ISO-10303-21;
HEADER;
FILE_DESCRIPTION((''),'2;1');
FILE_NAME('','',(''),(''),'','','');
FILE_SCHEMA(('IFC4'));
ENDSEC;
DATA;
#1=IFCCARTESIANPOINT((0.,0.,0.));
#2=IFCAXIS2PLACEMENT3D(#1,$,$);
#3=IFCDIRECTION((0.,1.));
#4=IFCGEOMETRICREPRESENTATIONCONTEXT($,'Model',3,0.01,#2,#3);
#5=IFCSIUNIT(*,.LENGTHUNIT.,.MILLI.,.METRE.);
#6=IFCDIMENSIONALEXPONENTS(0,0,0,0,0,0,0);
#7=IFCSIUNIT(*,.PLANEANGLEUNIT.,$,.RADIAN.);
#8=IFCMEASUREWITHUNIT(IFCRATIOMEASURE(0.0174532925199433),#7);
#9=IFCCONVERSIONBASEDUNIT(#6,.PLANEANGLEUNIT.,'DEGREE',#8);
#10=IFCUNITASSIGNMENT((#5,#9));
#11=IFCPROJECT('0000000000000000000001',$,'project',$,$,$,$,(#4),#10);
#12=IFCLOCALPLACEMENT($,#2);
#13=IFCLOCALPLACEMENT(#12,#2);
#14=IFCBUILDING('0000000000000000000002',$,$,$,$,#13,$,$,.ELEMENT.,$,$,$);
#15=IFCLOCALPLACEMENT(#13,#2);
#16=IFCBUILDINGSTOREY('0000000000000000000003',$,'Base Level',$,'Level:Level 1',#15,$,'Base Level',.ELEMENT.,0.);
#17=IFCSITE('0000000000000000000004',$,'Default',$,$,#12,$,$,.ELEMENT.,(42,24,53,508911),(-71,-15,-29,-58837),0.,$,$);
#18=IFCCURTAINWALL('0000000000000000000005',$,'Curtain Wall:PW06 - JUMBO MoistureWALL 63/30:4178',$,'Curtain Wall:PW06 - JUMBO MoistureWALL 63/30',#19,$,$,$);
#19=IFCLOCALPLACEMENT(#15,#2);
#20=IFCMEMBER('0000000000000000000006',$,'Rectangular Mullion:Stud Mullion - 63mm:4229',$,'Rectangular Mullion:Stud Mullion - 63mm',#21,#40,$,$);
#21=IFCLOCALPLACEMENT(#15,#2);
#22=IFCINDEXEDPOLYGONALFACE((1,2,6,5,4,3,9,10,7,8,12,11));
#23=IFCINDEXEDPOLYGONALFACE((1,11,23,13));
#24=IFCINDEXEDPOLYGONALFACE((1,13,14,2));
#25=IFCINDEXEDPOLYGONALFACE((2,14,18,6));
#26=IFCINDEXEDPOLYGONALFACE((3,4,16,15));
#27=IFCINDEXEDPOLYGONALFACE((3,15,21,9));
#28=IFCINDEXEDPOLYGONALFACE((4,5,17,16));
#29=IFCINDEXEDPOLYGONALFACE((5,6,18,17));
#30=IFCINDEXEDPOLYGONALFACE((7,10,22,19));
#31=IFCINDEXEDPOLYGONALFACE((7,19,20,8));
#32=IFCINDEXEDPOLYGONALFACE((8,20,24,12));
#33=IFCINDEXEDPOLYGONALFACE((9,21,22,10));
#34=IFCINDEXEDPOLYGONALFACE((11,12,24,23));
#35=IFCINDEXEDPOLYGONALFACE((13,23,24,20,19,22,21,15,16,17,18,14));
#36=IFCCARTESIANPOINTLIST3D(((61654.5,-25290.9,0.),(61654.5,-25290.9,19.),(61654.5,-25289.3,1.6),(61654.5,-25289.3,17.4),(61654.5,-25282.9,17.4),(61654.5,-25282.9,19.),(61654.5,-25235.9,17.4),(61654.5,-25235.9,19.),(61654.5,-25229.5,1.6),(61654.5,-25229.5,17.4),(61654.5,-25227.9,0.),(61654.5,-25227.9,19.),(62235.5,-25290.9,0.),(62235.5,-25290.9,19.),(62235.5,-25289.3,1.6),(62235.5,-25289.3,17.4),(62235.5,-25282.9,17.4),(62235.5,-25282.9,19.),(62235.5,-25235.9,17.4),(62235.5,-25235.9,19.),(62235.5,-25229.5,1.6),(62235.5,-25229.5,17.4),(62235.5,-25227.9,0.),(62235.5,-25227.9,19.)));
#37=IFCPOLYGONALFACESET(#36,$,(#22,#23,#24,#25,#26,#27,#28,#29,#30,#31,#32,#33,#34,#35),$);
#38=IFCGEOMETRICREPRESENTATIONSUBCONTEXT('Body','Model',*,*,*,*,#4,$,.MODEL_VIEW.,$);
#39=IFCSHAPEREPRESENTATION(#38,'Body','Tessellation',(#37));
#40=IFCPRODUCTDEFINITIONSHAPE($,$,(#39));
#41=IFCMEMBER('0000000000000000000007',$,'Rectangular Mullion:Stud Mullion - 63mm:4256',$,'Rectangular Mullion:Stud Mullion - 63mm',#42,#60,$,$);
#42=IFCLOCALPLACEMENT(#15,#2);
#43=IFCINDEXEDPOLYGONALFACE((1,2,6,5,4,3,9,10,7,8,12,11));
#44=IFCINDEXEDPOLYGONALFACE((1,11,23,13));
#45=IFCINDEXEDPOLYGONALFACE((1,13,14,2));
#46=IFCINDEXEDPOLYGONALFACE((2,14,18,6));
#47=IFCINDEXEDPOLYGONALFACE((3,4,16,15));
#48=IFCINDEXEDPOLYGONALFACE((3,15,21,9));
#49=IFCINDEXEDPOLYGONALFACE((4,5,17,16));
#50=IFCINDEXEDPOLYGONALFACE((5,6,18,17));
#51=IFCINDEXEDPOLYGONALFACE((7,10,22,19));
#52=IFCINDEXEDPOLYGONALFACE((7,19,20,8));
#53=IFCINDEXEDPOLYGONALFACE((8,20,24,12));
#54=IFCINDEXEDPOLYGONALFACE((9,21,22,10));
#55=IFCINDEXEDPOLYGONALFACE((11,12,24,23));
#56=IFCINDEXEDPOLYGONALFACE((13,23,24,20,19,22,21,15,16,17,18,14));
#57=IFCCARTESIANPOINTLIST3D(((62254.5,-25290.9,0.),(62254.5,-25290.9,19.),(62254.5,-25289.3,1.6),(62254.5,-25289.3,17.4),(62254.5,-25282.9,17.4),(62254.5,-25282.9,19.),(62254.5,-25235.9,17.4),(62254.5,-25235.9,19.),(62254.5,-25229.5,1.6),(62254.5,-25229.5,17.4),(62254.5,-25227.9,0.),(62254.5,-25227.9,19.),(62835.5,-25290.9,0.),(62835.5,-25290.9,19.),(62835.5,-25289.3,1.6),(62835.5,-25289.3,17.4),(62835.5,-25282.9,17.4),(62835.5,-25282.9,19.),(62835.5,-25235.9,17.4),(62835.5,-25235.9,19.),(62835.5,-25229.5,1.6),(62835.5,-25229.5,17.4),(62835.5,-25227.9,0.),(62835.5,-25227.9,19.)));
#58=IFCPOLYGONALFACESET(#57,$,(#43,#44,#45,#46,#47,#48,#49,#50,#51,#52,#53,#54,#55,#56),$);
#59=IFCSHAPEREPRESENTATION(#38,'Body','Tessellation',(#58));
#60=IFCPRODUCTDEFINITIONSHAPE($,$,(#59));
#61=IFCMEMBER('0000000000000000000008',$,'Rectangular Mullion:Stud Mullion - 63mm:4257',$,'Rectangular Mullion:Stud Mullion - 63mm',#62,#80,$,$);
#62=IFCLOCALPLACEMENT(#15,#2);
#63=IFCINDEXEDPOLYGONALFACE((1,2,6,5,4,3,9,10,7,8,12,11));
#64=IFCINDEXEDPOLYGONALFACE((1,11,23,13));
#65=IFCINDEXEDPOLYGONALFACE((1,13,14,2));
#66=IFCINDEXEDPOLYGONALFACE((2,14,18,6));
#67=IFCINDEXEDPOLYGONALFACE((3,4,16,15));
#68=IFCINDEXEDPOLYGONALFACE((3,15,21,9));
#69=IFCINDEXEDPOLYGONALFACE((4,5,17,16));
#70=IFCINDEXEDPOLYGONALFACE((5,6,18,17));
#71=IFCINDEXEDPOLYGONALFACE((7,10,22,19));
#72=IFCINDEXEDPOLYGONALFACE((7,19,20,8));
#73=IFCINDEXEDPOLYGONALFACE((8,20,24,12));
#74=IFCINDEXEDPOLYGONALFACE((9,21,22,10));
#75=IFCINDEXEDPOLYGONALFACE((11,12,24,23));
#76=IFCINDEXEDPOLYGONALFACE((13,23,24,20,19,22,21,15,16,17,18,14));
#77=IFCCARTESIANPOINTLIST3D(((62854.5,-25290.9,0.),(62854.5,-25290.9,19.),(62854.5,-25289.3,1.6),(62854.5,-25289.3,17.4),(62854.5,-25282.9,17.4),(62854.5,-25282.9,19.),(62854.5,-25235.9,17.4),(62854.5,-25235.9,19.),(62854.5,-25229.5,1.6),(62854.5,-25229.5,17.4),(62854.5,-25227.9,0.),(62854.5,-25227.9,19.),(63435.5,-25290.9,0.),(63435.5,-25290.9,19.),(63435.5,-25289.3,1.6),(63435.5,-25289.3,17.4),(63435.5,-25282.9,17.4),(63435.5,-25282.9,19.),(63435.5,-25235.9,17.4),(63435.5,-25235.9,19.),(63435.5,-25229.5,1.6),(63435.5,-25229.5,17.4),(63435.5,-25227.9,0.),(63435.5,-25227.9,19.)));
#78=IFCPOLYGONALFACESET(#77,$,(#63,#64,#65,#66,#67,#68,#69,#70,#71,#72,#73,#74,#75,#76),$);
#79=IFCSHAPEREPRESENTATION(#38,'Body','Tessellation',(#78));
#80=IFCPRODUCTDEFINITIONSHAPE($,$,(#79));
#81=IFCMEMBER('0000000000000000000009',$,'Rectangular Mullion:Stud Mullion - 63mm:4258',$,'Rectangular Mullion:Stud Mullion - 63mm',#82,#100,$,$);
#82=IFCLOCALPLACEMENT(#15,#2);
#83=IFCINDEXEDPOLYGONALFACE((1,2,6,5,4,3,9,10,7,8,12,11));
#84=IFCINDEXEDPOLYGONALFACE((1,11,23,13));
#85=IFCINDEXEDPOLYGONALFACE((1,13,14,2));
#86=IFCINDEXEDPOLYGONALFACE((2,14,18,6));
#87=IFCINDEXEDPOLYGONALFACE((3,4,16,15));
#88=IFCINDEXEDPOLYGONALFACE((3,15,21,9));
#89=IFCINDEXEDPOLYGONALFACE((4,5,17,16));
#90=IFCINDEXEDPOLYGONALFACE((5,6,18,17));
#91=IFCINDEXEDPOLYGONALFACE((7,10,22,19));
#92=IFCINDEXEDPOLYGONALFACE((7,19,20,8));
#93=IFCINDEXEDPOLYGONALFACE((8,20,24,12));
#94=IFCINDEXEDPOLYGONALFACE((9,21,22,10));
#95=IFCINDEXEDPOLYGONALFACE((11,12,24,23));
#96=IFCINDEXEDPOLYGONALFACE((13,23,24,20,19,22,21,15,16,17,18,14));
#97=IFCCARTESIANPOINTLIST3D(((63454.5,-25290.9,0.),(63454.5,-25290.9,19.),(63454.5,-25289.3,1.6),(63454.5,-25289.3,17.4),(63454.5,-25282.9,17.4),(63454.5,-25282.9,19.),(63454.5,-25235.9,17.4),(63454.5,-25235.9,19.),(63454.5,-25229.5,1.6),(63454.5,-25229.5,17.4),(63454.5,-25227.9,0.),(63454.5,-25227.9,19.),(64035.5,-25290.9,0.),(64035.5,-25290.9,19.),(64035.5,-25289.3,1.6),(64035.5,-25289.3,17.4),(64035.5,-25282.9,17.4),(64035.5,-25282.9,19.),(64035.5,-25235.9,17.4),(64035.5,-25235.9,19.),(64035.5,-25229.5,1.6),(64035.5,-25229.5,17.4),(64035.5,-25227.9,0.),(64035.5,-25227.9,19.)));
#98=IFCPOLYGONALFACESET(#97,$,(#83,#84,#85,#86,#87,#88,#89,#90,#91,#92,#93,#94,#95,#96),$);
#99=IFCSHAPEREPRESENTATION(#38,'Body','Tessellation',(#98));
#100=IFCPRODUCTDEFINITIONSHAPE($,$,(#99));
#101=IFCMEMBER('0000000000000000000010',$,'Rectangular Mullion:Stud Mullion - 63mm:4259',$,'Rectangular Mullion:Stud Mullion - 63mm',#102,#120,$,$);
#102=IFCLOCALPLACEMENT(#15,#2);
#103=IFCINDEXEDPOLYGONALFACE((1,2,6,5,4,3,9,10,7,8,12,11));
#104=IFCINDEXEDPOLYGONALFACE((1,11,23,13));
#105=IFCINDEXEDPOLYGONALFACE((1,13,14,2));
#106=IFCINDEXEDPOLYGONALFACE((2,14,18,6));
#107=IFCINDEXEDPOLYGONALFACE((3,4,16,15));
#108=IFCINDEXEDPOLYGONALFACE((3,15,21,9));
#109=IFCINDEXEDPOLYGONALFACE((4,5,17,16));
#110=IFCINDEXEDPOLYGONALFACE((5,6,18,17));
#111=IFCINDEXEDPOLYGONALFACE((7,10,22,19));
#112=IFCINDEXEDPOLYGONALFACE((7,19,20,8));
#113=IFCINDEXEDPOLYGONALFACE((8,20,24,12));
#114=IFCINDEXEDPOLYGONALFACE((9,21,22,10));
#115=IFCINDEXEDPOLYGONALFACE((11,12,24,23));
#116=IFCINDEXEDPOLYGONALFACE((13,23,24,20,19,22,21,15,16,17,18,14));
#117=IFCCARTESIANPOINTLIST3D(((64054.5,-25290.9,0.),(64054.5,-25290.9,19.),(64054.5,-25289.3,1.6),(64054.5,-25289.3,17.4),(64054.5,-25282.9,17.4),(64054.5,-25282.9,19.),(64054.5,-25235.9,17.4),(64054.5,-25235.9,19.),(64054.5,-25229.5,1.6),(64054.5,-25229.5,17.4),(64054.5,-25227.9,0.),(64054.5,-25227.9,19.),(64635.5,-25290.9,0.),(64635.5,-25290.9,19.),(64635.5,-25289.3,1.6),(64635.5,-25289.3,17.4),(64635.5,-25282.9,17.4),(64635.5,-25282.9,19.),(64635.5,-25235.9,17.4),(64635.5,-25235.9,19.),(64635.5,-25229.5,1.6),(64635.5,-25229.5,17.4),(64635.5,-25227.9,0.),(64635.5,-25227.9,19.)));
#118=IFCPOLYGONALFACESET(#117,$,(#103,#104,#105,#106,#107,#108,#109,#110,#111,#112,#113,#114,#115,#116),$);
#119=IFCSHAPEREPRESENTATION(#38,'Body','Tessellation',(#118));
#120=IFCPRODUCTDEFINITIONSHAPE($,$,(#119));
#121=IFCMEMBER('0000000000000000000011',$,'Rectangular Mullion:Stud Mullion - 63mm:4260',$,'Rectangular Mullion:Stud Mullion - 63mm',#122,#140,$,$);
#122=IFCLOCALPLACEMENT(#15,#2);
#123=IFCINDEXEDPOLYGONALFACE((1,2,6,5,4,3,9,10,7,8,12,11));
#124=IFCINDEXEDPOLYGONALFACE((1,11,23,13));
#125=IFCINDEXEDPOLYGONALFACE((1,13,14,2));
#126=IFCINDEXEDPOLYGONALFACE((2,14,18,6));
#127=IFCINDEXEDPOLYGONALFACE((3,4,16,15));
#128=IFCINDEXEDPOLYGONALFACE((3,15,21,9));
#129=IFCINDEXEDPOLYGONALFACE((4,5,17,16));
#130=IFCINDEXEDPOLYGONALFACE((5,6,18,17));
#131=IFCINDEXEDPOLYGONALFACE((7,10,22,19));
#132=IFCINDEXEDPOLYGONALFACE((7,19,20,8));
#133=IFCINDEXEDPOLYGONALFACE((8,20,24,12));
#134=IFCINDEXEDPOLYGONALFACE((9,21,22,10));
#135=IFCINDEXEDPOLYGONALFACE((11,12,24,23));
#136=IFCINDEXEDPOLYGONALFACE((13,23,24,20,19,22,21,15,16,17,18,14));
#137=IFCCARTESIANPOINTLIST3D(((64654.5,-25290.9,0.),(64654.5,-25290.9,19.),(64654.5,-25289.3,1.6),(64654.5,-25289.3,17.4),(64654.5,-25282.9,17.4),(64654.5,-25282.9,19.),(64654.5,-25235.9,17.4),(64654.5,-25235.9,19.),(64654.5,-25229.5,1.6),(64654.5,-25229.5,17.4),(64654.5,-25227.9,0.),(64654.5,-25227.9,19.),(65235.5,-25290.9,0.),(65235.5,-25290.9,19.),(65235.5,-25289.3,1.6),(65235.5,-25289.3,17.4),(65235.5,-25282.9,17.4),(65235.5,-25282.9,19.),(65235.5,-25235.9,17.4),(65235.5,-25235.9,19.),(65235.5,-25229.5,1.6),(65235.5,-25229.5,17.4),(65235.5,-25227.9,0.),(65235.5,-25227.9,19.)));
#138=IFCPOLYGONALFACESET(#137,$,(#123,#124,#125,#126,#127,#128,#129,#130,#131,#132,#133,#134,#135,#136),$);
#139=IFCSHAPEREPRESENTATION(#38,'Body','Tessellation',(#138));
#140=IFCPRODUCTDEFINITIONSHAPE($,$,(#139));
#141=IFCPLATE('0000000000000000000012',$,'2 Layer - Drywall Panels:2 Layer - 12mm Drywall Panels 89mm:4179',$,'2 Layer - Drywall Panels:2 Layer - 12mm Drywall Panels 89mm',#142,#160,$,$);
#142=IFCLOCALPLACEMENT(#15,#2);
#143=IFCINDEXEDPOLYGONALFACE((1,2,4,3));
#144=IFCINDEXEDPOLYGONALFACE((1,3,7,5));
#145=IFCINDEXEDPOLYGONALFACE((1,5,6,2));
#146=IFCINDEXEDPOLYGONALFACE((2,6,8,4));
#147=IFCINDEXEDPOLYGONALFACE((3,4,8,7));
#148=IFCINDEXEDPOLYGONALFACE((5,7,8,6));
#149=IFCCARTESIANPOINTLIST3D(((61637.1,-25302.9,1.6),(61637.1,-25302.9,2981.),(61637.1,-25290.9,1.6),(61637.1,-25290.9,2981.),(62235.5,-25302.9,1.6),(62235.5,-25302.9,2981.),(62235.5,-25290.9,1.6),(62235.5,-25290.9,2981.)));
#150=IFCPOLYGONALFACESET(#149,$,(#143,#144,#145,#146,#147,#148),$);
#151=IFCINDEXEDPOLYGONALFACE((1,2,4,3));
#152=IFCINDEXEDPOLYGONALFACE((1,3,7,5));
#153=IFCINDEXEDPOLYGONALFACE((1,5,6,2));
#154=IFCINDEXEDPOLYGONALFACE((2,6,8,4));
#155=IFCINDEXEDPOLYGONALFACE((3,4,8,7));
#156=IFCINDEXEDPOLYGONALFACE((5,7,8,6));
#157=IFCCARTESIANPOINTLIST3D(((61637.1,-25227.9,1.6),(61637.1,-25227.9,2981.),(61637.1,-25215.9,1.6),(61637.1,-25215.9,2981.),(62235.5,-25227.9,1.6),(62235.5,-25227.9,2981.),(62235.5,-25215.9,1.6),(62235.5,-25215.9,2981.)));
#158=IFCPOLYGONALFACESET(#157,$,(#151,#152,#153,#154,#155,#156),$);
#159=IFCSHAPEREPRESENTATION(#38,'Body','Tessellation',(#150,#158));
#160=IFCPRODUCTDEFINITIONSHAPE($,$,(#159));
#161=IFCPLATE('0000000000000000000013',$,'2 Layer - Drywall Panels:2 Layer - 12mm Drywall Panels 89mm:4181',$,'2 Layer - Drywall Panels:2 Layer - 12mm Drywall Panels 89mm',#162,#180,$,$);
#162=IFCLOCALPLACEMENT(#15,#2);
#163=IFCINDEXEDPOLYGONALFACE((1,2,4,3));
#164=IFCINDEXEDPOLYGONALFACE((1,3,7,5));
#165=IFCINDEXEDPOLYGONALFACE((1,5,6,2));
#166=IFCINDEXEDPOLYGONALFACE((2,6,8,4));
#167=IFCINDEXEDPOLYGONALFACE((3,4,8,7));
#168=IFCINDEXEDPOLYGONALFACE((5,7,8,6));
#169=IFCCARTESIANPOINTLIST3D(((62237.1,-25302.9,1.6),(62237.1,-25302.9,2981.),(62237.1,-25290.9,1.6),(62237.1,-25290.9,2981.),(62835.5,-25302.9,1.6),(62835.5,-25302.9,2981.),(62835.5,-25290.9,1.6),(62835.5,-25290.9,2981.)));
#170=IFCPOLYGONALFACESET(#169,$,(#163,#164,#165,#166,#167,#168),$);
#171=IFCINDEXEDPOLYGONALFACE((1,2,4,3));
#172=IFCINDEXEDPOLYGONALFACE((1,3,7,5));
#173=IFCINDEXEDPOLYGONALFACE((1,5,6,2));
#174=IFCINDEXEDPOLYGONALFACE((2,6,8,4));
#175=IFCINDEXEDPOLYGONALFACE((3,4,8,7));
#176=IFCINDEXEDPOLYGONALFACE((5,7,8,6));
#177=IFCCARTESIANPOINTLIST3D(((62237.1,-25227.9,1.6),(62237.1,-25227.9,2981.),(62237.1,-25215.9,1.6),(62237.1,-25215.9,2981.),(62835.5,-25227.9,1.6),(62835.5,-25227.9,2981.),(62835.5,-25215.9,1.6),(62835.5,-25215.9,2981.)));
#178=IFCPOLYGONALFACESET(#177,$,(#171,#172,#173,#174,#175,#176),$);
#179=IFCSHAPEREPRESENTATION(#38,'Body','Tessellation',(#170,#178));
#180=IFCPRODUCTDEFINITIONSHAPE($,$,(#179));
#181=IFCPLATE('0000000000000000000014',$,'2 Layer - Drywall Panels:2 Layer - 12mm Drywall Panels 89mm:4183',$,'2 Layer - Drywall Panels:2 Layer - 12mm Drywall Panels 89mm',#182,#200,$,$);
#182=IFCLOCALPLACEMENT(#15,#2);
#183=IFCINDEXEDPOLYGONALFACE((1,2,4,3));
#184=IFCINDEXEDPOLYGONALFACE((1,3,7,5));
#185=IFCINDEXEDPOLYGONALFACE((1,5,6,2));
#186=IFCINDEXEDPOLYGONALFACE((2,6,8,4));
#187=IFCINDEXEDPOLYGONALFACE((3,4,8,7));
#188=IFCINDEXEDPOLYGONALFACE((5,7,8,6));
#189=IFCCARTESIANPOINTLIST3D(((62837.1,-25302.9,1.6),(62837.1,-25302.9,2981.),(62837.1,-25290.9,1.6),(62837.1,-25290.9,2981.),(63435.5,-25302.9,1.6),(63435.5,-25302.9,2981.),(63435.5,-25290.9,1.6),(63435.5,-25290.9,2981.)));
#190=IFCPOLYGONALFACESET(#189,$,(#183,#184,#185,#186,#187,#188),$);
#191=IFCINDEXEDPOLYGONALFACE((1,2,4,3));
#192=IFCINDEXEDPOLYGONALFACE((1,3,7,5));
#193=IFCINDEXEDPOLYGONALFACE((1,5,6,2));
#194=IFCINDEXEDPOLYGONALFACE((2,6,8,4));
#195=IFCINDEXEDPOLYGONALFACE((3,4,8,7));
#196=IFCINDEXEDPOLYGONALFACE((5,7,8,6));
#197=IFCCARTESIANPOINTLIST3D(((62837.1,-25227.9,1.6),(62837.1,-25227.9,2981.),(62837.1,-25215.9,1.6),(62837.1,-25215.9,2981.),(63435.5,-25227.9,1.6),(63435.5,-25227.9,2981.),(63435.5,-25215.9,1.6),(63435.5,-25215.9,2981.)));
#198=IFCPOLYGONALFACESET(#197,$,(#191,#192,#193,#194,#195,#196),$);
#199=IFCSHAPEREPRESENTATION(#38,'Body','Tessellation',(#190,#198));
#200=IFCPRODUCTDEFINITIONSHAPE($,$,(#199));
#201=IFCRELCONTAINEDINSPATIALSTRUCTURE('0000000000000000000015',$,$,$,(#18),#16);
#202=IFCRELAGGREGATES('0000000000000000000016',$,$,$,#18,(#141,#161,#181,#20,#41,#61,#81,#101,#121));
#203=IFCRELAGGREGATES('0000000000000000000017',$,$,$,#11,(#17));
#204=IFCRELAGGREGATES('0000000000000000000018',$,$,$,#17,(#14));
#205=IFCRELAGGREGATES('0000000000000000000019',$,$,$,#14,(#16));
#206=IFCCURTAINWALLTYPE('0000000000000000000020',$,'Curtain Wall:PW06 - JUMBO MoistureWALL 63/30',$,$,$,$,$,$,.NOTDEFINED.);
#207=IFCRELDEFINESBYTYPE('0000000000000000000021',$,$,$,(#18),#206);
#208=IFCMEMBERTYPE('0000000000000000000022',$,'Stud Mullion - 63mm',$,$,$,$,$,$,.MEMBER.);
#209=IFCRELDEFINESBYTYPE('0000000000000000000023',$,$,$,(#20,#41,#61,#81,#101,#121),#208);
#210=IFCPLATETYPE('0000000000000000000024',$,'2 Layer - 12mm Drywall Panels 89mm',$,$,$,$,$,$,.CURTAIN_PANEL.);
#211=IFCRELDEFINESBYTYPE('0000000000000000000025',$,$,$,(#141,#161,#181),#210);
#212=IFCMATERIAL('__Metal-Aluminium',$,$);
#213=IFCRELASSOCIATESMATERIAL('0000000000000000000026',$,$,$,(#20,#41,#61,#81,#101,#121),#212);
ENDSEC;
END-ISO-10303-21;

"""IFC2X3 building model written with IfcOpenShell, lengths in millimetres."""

from ifc_helpers import new_model, entity, si_unit, converted_unit, direction, frame, frame_2d, origin, place, context, subcontext, project, spatial, polyline, rectangle, outline, extrude, source, transform, mapped, material, type_object, type_shapes, element, aggregate, save


model = new_model("IFC2X3")

# Units and contexts
model_context = context("Model", 3, precision=0.01, world=origin(), true_north=direction((0.0, 1.0)))
body_context = subcontext(model_context, "Body", "Model", "MODEL_VIEW")
ifc_project = project(units=[si_unit("LENGTHUNIT", "METRE", prefix="MILLI"), converted_unit("PLANEANGLEUNIT", "DEGREE", entity("IfcRatioMeasure", 0.0174532925199433), si_unit("PLANEANGLEUNIT", "RADIAN"), dimensions=[0, 0, 0, 0, 0, 0, 0])], contexts=[model_context])

# Site, building, storey
site_placement = place(None, origin())
site = spatial("IfcSite", under=ifc_project, at=site_placement, Name="Default", CompositionType="ELEMENT", RefLatitude=(42, 24, 53, 508911), RefLongitude=(-71, -15, -29, -58837), RefElevation=0.0)
building_placement = place(site_placement, origin())
building = spatial("IfcBuilding", under=site, at=building_placement, CompositionType="ELEMENT")
storey_placement = place(building_placement, origin())
storey = spatial("IfcBuildingStorey", under=building, at=storey_placement, Name="Base Level", ObjectType="Level:Level 1", LongName="Base Level", CompositionType="ELEMENT", Elevation=0.0)

# Curtain wall, members, plates
curtain_wall_type = type_object("IfcCurtainWallType", Name="Curtain Wall:PW06 - JUMBO MoistureWALL 63/30", PredefinedType="NOTDEFINED")
curtain_wall_placement = place(building_placement, origin())
curtain_wall = element("IfcCurtainWall", 1, at=curtain_wall_placement, inside=storey, type_object=curtain_wall_type, Name="Curtain Wall:PW06 - JUMBO MoistureWALL 63/30:4178", ObjectType="Curtain Wall:PW06 - JUMBO MoistureWALL 63/30")
ifc_material_1 = material(Name="__Metal-Aluminium")
member_type_1 = type_object("IfcMemberType", Name="Stud Mullion - 63mm", PredefinedType="MEMBER")
shared_shape_1 = source(origin(), body_context, "Body", "SweptSolid", [
    extrude(outline(polyline([(23.5, -6.6), (31.5, -6.6), (31.5, 12.4), (-31.5, 12.4), (-31.5, -6.6), (-23.5, -6.6), (-23.5, -5.0), (-29.9, -5.0), (-29.9, 10.8), (29.9, 10.8), (29.9, -5.0), (23.5, -5.0), (23.5, -6.6)])), frame((-12.4, 0.0, -581.0), z_axis=(0.0, 0.0, 1.0), x_axis=(0.0, -1.0, 0.0)), (0.0, 0.0, 1.0), 581.0),
])
type_shapes(member_type_1, [shared_shape_1])
member_1_placement = place(building_placement, frame((61654.5, -25259.4, 0.0), z_axis=(-1.0, 0.0, 0.0), x_axis=(0.0, 0.0, -1.0)))
member_1 = element("IfcMember", 2, at=member_1_placement, type_object=member_type_1, material=ifc_material_1, Name="Rectangular Mullion:Stud Mullion - 63mm:4229", ObjectType="Rectangular Mullion:Stud Mullion - 63mm", context=body_context, shape_type="MappedRepresentation", body=[
    mapped(shared_shape_1, transform((0.0, 0.0, 0.0), scale=1.0)),
])
member_2_placement = place(building_placement, frame((62254.5, -25259.4, 0.0), z_axis=(-1.0, 0.0, 0.0), x_axis=(0.0, 0.0, -1.0)))
member_2 = element("IfcMember", 3, at=member_2_placement, type_object=member_type_1, material=ifc_material_1, Name="Rectangular Mullion:Stud Mullion - 63mm:4256", ObjectType="Rectangular Mullion:Stud Mullion - 63mm", context=body_context, shape_type="MappedRepresentation", body=[
    mapped(shared_shape_1, transform((0.0, 0.0, 0.0), scale=1.0)),
])
member_3_placement = place(building_placement, frame((62854.5, -25259.4, 0.0), z_axis=(-1.0, 0.0, 0.0), x_axis=(0.0, 0.0, -1.0)))
member_3 = element("IfcMember", 4, at=member_3_placement, type_object=member_type_1, material=ifc_material_1, Name="Rectangular Mullion:Stud Mullion - 63mm:4257", ObjectType="Rectangular Mullion:Stud Mullion - 63mm", context=body_context, shape_type="MappedRepresentation", body=[
    mapped(shared_shape_1, transform((0.0, 0.0, 0.0), scale=1.0)),
])
member_4_placement = place(building_placement, frame((63454.5, -25259.4, 0.0), z_axis=(-1.0, 0.0, 0.0), x_axis=(0.0, 0.0, -1.0)))
member_4 = element("IfcMember", 5, at=member_4_placement, type_object=member_type_1, material=ifc_material_1, Name="Rectangular Mullion:Stud Mullion - 63mm:4258", ObjectType="Rectangular Mullion:Stud Mullion - 63mm", context=body_context, shape_type="MappedRepresentation", body=[
    mapped(shared_shape_1, transform((0.0, 0.0, 0.0), scale=1.0)),
])
member_5_placement = place(building_placement, frame((64054.5, -25259.4, 0.0), z_axis=(-1.0, 0.0, 0.0), x_axis=(0.0, 0.0, -1.0)))
member_5 = element("IfcMember", 6, at=member_5_placement, type_object=member_type_1, material=ifc_material_1, Name="Rectangular Mullion:Stud Mullion - 63mm:4259", ObjectType="Rectangular Mullion:Stud Mullion - 63mm", context=body_context, shape_type="MappedRepresentation", body=[
    mapped(shared_shape_1, transform((0.0, 0.0, 0.0), scale=1.0)),
])
member_6_placement = place(building_placement, frame((64654.5, -25259.4, 0.0), z_axis=(-1.0, 0.0, 0.0), x_axis=(0.0, 0.0, -1.0)))
member_6 = element("IfcMember", 7, at=member_6_placement, type_object=member_type_1, material=ifc_material_1, Name="Rectangular Mullion:Stud Mullion - 63mm:4260", ObjectType="Rectangular Mullion:Stud Mullion - 63mm", context=body_context, shape_type="MappedRepresentation", body=[
    mapped(shared_shape_1, transform((0.0, 0.0, 0.0), scale=1.0)),
])
plate_type = type_object("IfcPlateType", Name="2 Layer - 12mm Drywall Panels 89mm", PredefinedType="CURTAIN_PANEL")
shared_shape_2 = source(origin(), body_context, "Body", "SweptSolid", [
    extrude(rectangle(XDim=598.4, YDim=12.0, at=frame_2d((0.0, 0.0), x_axis=(1.0, 0.0))), frame((0.0, -37.5, 0.0), z_axis=(0.0, 0.0, 1.0), x_axis=(-1.0, 0.0, 0.0)), (0.0, 0.0, 1.0), 2979.4),
    extrude(rectangle(XDim=12.0, YDim=598.4, at=frame_2d((0.0, 0.0), x_axis=(1.0, 0.0))), frame((0.0, 37.5, 0.0), z_axis=(0.0, 0.0, 1.0), x_axis=(0.0, 1.0, 0.0)), (0.0, 0.0, 1.0), 2979.4),
])
type_shapes(plate_type, [shared_shape_2])
plate_1_placement = place(curtain_wall_placement, frame((61936.3, -25259.4, 1.6)))
plate_1 = element("IfcPlate", 8, at=plate_1_placement, type_object=plate_type, Name="2 Layer - Drywall Panels:2 Layer - 12mm Drywall Panels 89mm:4179", ObjectType="2 Layer - Drywall Panels:2 Layer - 12mm Drywall Panels 89mm", context=body_context, shape_type="MappedRepresentation", body=[
    mapped(shared_shape_2, transform((0.0, 0.0, 0.0), scale=1.0)),
])
plate_2_placement = place(curtain_wall_placement, frame((62536.3, -25259.4, 1.6)))
plate_2 = element("IfcPlate", 9, at=plate_2_placement, type_object=plate_type, Name="2 Layer - Drywall Panels:2 Layer - 12mm Drywall Panels 89mm:4181", ObjectType="2 Layer - Drywall Panels:2 Layer - 12mm Drywall Panels 89mm", context=body_context, shape_type="MappedRepresentation", body=[
    mapped(shared_shape_2, transform((0.0, 0.0, 0.0), scale=1.0)),
])
plate_3_placement = place(curtain_wall_placement, frame((63136.3, -25259.4, 1.6)))
plate_3 = element("IfcPlate", 10, at=plate_3_placement, type_object=plate_type, Name="2 Layer - Drywall Panels:2 Layer - 12mm Drywall Panels 89mm:4183", ObjectType="2 Layer - Drywall Panels:2 Layer - 12mm Drywall Panels 89mm", context=body_context, shape_type="MappedRepresentation", body=[
    mapped(shared_shape_2, transform((0.0, 0.0, 0.0), scale=1.0)),
])
aggregate(curtain_wall, [plate_1, plate_2, plate_3, member_1, member_2, member_3, member_4, member_5, member_6])

save(model, "model.ifc")
